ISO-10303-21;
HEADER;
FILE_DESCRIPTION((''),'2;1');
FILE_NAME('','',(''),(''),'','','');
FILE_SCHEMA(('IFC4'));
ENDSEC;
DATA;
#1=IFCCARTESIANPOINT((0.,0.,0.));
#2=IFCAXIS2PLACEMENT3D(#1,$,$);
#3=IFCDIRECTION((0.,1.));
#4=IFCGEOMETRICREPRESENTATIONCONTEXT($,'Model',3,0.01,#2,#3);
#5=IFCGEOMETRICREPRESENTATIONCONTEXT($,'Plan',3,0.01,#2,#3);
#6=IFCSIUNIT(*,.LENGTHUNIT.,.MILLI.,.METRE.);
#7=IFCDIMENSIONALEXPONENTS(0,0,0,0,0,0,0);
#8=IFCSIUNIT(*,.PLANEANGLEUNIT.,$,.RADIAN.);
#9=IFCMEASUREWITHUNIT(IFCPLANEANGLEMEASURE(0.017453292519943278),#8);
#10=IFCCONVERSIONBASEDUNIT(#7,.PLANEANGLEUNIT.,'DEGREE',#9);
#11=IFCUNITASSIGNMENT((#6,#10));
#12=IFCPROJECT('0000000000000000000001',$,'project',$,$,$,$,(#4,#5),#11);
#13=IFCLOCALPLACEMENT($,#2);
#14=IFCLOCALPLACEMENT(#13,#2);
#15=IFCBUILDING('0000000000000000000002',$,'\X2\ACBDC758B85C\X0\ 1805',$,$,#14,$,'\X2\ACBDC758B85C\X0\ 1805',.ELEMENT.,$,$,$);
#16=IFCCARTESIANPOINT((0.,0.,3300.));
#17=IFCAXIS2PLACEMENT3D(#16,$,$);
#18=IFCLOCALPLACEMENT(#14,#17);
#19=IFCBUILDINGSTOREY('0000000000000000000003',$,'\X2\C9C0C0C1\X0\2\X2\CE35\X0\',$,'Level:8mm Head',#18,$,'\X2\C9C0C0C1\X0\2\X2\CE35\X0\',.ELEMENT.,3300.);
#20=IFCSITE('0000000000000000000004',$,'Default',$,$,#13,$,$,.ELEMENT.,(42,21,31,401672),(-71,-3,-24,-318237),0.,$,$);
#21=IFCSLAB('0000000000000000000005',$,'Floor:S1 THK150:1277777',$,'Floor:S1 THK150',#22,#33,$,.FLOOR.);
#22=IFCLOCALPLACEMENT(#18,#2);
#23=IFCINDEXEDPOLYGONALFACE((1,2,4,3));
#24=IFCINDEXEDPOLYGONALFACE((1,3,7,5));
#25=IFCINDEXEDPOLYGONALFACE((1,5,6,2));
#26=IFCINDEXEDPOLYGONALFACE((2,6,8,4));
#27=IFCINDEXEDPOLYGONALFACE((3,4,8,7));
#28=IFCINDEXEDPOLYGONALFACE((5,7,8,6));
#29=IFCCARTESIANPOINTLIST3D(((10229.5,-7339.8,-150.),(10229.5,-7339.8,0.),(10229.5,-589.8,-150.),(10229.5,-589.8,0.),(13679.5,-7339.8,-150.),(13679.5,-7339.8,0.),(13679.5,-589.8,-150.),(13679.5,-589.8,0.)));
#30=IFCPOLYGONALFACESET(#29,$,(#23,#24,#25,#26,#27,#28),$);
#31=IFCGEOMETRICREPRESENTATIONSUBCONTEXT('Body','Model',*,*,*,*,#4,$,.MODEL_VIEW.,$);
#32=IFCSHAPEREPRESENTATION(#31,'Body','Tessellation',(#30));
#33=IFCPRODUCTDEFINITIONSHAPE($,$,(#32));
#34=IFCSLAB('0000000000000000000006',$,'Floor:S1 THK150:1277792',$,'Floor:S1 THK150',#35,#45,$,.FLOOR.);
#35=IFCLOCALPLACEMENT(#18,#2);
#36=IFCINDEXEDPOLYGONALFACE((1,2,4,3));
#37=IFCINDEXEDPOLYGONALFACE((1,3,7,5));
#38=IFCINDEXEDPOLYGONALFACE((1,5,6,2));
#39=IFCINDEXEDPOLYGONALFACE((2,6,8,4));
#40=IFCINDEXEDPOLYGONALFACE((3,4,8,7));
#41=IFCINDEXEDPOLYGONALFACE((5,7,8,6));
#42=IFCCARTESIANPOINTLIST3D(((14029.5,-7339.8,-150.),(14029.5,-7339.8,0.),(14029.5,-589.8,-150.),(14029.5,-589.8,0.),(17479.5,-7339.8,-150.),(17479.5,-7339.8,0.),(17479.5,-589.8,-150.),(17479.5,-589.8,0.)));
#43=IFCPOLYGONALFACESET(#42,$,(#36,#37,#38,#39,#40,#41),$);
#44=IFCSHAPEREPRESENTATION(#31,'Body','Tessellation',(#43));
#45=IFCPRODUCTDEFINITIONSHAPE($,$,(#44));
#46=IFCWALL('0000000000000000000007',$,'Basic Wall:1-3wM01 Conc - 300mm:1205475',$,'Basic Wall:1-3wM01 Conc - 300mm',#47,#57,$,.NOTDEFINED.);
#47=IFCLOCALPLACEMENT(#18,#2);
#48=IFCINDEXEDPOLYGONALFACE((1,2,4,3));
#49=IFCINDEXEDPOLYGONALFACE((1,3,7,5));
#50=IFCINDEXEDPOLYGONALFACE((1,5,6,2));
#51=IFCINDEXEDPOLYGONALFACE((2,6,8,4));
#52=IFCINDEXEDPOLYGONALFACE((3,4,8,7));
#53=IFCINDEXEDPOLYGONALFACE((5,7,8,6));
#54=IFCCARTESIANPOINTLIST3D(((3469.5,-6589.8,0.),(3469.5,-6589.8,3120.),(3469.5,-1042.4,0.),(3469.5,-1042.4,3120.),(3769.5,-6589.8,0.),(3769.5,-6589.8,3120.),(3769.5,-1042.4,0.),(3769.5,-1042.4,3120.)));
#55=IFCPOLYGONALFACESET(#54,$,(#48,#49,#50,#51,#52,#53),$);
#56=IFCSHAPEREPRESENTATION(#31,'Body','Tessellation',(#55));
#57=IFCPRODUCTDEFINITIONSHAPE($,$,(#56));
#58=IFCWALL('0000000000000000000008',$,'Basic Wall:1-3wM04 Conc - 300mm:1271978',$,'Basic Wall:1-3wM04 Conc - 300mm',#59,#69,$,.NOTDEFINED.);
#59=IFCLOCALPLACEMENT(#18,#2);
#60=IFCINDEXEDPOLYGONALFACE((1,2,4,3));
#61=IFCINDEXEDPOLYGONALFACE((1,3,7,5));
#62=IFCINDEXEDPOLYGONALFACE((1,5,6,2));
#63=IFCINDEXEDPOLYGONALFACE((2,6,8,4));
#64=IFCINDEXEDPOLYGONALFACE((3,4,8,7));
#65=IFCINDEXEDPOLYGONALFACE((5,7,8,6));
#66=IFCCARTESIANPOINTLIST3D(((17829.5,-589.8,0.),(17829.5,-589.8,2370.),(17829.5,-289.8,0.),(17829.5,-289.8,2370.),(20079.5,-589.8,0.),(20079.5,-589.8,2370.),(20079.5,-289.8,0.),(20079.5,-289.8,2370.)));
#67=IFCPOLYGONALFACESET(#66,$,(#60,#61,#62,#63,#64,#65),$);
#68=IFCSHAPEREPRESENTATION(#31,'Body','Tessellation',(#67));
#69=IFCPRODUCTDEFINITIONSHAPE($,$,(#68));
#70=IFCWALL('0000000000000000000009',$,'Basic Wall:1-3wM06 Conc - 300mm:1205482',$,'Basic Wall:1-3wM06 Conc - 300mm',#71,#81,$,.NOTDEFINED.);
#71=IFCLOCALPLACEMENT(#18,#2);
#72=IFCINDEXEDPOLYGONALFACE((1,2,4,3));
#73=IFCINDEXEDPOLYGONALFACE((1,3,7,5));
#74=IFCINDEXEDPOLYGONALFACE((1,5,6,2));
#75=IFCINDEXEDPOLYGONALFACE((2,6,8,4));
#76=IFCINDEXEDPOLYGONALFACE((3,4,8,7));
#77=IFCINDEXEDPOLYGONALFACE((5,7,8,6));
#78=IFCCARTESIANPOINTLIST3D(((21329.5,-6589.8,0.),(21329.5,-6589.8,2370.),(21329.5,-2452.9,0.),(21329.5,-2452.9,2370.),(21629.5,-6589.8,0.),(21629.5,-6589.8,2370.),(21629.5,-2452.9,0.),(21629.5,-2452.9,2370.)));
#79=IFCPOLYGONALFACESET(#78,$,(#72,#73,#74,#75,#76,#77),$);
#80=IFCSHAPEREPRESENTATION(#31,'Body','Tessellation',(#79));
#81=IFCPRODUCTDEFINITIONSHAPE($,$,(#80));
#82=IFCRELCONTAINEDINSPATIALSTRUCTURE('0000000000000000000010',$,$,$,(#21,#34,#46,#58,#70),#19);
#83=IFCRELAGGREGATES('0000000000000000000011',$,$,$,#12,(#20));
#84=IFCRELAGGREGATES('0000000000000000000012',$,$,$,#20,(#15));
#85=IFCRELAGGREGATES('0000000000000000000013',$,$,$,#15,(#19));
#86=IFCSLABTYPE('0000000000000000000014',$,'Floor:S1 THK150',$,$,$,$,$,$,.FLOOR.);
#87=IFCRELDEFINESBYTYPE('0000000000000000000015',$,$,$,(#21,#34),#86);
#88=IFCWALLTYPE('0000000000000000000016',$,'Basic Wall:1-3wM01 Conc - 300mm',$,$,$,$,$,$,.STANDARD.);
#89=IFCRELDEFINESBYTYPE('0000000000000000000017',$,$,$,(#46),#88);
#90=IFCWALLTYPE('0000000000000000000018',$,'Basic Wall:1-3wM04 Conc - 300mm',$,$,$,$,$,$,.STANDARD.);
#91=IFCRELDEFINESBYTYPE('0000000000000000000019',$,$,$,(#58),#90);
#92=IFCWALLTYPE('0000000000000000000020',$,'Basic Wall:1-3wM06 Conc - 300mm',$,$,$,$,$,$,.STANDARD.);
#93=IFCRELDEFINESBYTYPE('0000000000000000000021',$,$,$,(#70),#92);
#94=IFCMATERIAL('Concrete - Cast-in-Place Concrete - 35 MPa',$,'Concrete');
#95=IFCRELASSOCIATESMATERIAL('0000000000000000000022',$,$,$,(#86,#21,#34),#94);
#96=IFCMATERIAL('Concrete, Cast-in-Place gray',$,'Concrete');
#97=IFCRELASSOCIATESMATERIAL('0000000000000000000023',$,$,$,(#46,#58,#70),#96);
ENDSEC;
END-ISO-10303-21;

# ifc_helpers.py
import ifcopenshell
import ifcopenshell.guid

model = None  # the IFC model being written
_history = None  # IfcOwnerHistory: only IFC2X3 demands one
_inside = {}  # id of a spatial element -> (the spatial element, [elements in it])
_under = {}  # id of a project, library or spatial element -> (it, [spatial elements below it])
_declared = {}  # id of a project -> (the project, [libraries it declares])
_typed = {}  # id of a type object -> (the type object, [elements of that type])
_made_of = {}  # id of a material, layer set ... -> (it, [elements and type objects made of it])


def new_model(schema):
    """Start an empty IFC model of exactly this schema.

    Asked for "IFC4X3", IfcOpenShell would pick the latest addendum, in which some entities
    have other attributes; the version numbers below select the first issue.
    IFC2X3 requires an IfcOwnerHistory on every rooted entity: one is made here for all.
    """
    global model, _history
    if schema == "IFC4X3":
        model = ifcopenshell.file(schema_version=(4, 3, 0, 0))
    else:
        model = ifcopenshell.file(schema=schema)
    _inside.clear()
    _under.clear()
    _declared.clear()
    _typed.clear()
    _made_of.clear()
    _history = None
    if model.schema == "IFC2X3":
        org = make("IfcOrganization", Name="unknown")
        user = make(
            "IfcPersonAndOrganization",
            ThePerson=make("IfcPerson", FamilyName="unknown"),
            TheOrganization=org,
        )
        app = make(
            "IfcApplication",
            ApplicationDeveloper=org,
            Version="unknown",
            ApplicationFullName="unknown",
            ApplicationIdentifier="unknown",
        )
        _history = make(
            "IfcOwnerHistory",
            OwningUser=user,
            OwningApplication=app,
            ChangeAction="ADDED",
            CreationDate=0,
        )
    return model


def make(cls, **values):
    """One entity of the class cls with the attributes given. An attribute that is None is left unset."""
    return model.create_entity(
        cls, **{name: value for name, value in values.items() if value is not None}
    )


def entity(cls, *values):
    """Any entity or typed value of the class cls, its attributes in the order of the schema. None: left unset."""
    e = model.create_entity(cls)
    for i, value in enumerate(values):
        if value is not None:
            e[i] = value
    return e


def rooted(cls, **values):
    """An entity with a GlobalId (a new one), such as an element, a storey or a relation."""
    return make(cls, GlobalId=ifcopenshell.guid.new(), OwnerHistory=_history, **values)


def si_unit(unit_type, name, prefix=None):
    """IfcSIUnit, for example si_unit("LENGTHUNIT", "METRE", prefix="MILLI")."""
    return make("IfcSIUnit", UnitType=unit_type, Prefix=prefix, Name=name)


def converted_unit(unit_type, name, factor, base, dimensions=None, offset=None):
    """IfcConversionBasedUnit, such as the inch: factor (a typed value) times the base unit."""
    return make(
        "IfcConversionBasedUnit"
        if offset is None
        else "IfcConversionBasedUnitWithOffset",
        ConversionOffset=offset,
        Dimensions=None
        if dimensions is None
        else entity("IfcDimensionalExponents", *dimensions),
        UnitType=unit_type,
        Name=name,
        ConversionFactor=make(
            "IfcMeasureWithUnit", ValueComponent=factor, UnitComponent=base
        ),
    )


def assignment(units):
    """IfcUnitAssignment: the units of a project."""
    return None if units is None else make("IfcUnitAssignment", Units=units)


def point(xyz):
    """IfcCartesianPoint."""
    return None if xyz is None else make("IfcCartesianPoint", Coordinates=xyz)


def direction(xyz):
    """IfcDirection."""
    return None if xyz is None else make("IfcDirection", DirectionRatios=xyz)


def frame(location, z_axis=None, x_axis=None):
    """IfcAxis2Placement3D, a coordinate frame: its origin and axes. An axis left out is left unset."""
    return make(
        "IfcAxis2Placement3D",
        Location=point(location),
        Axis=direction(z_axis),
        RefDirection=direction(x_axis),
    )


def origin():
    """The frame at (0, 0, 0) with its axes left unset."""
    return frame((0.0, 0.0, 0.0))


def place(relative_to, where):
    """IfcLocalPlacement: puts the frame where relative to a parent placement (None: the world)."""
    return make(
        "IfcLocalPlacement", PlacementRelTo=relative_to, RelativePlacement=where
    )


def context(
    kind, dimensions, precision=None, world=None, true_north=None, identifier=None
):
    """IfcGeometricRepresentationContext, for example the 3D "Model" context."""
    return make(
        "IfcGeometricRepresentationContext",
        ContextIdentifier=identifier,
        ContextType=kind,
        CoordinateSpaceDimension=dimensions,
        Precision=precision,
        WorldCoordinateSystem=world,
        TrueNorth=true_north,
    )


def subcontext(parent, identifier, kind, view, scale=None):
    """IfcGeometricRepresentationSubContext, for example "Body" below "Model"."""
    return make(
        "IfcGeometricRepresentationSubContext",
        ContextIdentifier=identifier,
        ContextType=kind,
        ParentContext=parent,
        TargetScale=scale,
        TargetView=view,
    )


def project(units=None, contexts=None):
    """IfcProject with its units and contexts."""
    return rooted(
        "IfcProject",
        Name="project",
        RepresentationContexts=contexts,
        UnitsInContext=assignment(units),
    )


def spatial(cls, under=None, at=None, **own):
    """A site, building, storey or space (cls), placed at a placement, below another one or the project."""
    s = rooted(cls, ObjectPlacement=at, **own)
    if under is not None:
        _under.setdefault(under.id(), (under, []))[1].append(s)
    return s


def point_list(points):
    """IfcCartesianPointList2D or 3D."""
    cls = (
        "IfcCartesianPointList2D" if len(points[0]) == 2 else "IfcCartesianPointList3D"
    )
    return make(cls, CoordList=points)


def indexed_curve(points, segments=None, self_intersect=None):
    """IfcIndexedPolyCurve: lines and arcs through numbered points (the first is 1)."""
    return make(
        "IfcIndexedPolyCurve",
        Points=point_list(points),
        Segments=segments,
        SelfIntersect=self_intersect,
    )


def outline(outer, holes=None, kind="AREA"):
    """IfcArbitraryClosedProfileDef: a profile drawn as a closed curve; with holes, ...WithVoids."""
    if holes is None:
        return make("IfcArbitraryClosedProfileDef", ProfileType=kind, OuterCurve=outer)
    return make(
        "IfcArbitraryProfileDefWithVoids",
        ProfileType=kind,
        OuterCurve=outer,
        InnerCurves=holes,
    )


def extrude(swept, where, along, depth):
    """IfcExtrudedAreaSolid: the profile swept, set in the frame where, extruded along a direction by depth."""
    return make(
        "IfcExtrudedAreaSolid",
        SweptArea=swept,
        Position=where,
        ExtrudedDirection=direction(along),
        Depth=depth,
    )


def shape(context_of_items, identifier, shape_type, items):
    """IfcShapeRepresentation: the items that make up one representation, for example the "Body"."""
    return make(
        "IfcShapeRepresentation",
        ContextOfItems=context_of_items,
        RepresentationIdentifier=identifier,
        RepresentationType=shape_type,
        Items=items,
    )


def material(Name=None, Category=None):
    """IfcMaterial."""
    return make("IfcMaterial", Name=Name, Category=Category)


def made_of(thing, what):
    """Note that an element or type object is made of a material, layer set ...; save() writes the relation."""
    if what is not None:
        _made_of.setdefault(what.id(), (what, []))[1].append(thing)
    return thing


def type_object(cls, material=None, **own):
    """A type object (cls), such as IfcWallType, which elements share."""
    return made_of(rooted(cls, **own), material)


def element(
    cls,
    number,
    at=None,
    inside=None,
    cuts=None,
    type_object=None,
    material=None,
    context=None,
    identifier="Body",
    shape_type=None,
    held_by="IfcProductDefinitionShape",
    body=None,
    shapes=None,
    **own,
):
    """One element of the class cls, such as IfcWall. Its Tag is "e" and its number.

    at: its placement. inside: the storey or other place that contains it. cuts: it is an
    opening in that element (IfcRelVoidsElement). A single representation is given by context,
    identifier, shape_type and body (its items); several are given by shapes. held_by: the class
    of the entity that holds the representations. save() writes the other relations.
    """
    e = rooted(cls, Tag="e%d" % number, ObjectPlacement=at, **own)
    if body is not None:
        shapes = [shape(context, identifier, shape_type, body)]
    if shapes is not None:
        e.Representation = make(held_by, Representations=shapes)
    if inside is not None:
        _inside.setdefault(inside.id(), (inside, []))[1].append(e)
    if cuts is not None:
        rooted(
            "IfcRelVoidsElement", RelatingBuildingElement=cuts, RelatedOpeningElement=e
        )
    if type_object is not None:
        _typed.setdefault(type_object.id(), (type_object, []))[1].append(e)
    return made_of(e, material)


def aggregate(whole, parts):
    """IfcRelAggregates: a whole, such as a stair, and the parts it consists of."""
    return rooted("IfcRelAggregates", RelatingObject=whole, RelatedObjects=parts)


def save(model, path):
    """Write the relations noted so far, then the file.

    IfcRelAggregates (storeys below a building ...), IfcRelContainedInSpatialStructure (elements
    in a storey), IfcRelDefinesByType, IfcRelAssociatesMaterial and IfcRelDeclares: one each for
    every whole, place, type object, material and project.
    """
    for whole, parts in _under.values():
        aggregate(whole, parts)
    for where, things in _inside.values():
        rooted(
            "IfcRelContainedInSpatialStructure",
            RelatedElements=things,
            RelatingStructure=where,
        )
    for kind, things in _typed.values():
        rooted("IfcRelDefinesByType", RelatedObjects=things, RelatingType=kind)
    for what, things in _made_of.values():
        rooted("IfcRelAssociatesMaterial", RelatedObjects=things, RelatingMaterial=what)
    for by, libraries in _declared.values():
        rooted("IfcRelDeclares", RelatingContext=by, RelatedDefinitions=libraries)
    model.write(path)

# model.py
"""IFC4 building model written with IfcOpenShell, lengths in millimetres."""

from ifc_helpers import new_model, entity, si_unit, converted_unit, direction, frame, origin, place, context, subcontext, project, spatial, indexed_curve, outline, extrude, material, type_object, element, save


model = new_model("IFC4")

# Units and contexts
model_context = context("Model", 3, precision=0.01, world=origin(), true_north=direction((0.0, 1.0)))
plan_context = context("Plan", 3, precision=0.01, world=origin(), true_north=direction((0.0, 1.0)))
body_context = subcontext(model_context, "Body", "Model", "MODEL_VIEW")
ifc_project = project(units=[si_unit("LENGTHUNIT", "METRE", prefix="MILLI"), converted_unit("PLANEANGLEUNIT", "DEGREE", entity("IfcPlaneAngleMeasure", 0.017453292519943278), si_unit("PLANEANGLEUNIT", "RADIAN"), dimensions=[0, 0, 0, 0, 0, 0, 0])], contexts=[model_context, plan_context])

# Site, building, storey
site_placement = place(None, origin())
site = spatial("IfcSite", under=ifc_project, at=site_placement, Name="Default", CompositionType="ELEMENT", RefLatitude=(42, 21, 31, 401672), RefLongitude=(-71, -3, -24, -318237), RefElevation=0.0)
building_placement = place(site_placement, origin())
building = spatial("IfcBuilding", under=site, at=building_placement, Name="경의로 1805", LongName="경의로 1805", CompositionType="ELEMENT")
storey_placement = place(building_placement, frame((0.0, 0.0, 3300.0)))
storey = spatial("IfcBuildingStorey", under=building, at=storey_placement, Name="지상2층", ObjectType="Level:8mm Head", LongName="지상2층", CompositionType="ELEMENT", Elevation=3300.0)

# Shared definitions
ifc_material_1 = material(Name="Concrete - Cast-in-Place Concrete - 35 MPa", Category="Concrete")

# Slabs
slab_type_1 = type_object("IfcSlabType", Name="Floor:S1 THK150", PredefinedType="FLOOR", material=ifc_material_1)
slab_1_placement = place(storey_placement, origin())
element("IfcSlab", 1, at=slab_1_placement, inside=storey, type_object=slab_type_1, material=ifc_material_1, Name="Floor:S1 THK150:1277777", ObjectType="Floor:S1 THK150", PredefinedType="FLOOR", context=body_context, shape_type="SweptSolid", body=[
    extrude(outline(indexed_curve([(-3375.0, -1725.0), (3375.0, -1725.0), (3375.0, 1725.0), (-3375.0, 1725.0), (-3375.0, -1725.0)], self_intersect=False)), frame((11954.5, -3964.8, 0.0), z_axis=(0.0, 0.0, -1.0), x_axis=(0.0, 1.0, 0.0)), (0.0, 0.0, 1.0), 150.0),
])
slab_2_placement = place(storey_placement, origin())
element("IfcSlab", 2, at=slab_2_placement, inside=storey, type_object=slab_type_1, material=ifc_material_1, Name="Floor:S1 THK150:1277792", ObjectType="Floor:S1 THK150", PredefinedType="FLOOR", context=body_context, shape_type="SweptSolid", body=[
    extrude(outline(indexed_curve([(-3375.0, -1725.0), (3375.0, -1725.0), (3375.0, 1725.0), (-3375.0, 1725.0), (-3375.0, -1725.0)], self_intersect=False)), frame((15754.5, -3964.8, 0.0), z_axis=(0.0, 0.0, -1.0), x_axis=(0.0, 1.0, 0.0)), (0.0, 0.0, 1.0), 150.0),
])

# Walls
ifc_material_2 = material(Name="Concrete, Cast-in-Place gray", Category="Concrete")
wall_type_1 = type_object("IfcWallType", Name="Basic Wall:1-3wM01 Conc - 300mm", PredefinedType="STANDARD")
wall_1_placement = place(storey_placement, frame((3619.5, -6589.8, 0.0), z_axis=(0.0, 0.0, 1.0), x_axis=(0.0, 1.0, 0.0)))
element("IfcWall", 3, at=wall_1_placement, inside=storey, type_object=wall_type_1, material=ifc_material_2, Name="Basic Wall:1-3wM01 Conc - 300mm:1205475", ObjectType="Basic Wall:1-3wM01 Conc - 300mm", PredefinedType="NOTDEFINED", context=body_context, shape_type="SweptSolid", body=[
    extrude(outline(indexed_curve([(5547.4, 150.0), (0.0, 150.0), (0.0, -150.0), (5547.4, -150.0), (5547.4, 150.0)], self_intersect=False)), origin(), (0.0, 0.0, 1.0), 3120.0),
])
wall_type_2 = type_object("IfcWallType", Name="Basic Wall:1-3wM04 Conc - 300mm", PredefinedType="STANDARD")
wall_2_placement = place(storey_placement, frame((17829.5, -439.8, 0.0)))
element("IfcWall", 4, at=wall_2_placement, inside=storey, type_object=wall_type_2, material=ifc_material_2, Name="Basic Wall:1-3wM04 Conc - 300mm:1271978", ObjectType="Basic Wall:1-3wM04 Conc - 300mm", PredefinedType="NOTDEFINED", context=body_context, shape_type="SweptSolid", body=[
    extrude(outline(indexed_curve([(2250.0, 150.0), (0.0, 150.0), (0.0, -150.0), (2250.0, -150.0), (2250.0, 150.0)], self_intersect=False)), origin(), (0.0, 0.0, 1.0), 2370.0),
])
wall_type_3 = type_object("IfcWallType", Name="Basic Wall:1-3wM06 Conc - 300mm", PredefinedType="STANDARD")
wall_3_placement = place(storey_placement, frame((21479.5, -2452.9, 0.0), z_axis=(0.0, 0.0, 1.0), x_axis=(0.0, -1.0, 0.0)))
element("IfcWall", 5, at=wall_3_placement, inside=storey, type_object=wall_type_3, material=ifc_material_2, Name="Basic Wall:1-3wM06 Conc - 300mm:1205482", ObjectType="Basic Wall:1-3wM06 Conc - 300mm", PredefinedType="NOTDEFINED", context=body_context, shape_type="SweptSolid", body=[
    extrude(outline(indexed_curve([(4136.9, 150.0), (0.0, 150.0), (0.0, -150.0), (4136.9, -150.0), (4136.9, 150.0)], self_intersect=False)), origin(), (0.0, 0.0, 1.0), 2370.0),
])

save(model, "model.ifc")
